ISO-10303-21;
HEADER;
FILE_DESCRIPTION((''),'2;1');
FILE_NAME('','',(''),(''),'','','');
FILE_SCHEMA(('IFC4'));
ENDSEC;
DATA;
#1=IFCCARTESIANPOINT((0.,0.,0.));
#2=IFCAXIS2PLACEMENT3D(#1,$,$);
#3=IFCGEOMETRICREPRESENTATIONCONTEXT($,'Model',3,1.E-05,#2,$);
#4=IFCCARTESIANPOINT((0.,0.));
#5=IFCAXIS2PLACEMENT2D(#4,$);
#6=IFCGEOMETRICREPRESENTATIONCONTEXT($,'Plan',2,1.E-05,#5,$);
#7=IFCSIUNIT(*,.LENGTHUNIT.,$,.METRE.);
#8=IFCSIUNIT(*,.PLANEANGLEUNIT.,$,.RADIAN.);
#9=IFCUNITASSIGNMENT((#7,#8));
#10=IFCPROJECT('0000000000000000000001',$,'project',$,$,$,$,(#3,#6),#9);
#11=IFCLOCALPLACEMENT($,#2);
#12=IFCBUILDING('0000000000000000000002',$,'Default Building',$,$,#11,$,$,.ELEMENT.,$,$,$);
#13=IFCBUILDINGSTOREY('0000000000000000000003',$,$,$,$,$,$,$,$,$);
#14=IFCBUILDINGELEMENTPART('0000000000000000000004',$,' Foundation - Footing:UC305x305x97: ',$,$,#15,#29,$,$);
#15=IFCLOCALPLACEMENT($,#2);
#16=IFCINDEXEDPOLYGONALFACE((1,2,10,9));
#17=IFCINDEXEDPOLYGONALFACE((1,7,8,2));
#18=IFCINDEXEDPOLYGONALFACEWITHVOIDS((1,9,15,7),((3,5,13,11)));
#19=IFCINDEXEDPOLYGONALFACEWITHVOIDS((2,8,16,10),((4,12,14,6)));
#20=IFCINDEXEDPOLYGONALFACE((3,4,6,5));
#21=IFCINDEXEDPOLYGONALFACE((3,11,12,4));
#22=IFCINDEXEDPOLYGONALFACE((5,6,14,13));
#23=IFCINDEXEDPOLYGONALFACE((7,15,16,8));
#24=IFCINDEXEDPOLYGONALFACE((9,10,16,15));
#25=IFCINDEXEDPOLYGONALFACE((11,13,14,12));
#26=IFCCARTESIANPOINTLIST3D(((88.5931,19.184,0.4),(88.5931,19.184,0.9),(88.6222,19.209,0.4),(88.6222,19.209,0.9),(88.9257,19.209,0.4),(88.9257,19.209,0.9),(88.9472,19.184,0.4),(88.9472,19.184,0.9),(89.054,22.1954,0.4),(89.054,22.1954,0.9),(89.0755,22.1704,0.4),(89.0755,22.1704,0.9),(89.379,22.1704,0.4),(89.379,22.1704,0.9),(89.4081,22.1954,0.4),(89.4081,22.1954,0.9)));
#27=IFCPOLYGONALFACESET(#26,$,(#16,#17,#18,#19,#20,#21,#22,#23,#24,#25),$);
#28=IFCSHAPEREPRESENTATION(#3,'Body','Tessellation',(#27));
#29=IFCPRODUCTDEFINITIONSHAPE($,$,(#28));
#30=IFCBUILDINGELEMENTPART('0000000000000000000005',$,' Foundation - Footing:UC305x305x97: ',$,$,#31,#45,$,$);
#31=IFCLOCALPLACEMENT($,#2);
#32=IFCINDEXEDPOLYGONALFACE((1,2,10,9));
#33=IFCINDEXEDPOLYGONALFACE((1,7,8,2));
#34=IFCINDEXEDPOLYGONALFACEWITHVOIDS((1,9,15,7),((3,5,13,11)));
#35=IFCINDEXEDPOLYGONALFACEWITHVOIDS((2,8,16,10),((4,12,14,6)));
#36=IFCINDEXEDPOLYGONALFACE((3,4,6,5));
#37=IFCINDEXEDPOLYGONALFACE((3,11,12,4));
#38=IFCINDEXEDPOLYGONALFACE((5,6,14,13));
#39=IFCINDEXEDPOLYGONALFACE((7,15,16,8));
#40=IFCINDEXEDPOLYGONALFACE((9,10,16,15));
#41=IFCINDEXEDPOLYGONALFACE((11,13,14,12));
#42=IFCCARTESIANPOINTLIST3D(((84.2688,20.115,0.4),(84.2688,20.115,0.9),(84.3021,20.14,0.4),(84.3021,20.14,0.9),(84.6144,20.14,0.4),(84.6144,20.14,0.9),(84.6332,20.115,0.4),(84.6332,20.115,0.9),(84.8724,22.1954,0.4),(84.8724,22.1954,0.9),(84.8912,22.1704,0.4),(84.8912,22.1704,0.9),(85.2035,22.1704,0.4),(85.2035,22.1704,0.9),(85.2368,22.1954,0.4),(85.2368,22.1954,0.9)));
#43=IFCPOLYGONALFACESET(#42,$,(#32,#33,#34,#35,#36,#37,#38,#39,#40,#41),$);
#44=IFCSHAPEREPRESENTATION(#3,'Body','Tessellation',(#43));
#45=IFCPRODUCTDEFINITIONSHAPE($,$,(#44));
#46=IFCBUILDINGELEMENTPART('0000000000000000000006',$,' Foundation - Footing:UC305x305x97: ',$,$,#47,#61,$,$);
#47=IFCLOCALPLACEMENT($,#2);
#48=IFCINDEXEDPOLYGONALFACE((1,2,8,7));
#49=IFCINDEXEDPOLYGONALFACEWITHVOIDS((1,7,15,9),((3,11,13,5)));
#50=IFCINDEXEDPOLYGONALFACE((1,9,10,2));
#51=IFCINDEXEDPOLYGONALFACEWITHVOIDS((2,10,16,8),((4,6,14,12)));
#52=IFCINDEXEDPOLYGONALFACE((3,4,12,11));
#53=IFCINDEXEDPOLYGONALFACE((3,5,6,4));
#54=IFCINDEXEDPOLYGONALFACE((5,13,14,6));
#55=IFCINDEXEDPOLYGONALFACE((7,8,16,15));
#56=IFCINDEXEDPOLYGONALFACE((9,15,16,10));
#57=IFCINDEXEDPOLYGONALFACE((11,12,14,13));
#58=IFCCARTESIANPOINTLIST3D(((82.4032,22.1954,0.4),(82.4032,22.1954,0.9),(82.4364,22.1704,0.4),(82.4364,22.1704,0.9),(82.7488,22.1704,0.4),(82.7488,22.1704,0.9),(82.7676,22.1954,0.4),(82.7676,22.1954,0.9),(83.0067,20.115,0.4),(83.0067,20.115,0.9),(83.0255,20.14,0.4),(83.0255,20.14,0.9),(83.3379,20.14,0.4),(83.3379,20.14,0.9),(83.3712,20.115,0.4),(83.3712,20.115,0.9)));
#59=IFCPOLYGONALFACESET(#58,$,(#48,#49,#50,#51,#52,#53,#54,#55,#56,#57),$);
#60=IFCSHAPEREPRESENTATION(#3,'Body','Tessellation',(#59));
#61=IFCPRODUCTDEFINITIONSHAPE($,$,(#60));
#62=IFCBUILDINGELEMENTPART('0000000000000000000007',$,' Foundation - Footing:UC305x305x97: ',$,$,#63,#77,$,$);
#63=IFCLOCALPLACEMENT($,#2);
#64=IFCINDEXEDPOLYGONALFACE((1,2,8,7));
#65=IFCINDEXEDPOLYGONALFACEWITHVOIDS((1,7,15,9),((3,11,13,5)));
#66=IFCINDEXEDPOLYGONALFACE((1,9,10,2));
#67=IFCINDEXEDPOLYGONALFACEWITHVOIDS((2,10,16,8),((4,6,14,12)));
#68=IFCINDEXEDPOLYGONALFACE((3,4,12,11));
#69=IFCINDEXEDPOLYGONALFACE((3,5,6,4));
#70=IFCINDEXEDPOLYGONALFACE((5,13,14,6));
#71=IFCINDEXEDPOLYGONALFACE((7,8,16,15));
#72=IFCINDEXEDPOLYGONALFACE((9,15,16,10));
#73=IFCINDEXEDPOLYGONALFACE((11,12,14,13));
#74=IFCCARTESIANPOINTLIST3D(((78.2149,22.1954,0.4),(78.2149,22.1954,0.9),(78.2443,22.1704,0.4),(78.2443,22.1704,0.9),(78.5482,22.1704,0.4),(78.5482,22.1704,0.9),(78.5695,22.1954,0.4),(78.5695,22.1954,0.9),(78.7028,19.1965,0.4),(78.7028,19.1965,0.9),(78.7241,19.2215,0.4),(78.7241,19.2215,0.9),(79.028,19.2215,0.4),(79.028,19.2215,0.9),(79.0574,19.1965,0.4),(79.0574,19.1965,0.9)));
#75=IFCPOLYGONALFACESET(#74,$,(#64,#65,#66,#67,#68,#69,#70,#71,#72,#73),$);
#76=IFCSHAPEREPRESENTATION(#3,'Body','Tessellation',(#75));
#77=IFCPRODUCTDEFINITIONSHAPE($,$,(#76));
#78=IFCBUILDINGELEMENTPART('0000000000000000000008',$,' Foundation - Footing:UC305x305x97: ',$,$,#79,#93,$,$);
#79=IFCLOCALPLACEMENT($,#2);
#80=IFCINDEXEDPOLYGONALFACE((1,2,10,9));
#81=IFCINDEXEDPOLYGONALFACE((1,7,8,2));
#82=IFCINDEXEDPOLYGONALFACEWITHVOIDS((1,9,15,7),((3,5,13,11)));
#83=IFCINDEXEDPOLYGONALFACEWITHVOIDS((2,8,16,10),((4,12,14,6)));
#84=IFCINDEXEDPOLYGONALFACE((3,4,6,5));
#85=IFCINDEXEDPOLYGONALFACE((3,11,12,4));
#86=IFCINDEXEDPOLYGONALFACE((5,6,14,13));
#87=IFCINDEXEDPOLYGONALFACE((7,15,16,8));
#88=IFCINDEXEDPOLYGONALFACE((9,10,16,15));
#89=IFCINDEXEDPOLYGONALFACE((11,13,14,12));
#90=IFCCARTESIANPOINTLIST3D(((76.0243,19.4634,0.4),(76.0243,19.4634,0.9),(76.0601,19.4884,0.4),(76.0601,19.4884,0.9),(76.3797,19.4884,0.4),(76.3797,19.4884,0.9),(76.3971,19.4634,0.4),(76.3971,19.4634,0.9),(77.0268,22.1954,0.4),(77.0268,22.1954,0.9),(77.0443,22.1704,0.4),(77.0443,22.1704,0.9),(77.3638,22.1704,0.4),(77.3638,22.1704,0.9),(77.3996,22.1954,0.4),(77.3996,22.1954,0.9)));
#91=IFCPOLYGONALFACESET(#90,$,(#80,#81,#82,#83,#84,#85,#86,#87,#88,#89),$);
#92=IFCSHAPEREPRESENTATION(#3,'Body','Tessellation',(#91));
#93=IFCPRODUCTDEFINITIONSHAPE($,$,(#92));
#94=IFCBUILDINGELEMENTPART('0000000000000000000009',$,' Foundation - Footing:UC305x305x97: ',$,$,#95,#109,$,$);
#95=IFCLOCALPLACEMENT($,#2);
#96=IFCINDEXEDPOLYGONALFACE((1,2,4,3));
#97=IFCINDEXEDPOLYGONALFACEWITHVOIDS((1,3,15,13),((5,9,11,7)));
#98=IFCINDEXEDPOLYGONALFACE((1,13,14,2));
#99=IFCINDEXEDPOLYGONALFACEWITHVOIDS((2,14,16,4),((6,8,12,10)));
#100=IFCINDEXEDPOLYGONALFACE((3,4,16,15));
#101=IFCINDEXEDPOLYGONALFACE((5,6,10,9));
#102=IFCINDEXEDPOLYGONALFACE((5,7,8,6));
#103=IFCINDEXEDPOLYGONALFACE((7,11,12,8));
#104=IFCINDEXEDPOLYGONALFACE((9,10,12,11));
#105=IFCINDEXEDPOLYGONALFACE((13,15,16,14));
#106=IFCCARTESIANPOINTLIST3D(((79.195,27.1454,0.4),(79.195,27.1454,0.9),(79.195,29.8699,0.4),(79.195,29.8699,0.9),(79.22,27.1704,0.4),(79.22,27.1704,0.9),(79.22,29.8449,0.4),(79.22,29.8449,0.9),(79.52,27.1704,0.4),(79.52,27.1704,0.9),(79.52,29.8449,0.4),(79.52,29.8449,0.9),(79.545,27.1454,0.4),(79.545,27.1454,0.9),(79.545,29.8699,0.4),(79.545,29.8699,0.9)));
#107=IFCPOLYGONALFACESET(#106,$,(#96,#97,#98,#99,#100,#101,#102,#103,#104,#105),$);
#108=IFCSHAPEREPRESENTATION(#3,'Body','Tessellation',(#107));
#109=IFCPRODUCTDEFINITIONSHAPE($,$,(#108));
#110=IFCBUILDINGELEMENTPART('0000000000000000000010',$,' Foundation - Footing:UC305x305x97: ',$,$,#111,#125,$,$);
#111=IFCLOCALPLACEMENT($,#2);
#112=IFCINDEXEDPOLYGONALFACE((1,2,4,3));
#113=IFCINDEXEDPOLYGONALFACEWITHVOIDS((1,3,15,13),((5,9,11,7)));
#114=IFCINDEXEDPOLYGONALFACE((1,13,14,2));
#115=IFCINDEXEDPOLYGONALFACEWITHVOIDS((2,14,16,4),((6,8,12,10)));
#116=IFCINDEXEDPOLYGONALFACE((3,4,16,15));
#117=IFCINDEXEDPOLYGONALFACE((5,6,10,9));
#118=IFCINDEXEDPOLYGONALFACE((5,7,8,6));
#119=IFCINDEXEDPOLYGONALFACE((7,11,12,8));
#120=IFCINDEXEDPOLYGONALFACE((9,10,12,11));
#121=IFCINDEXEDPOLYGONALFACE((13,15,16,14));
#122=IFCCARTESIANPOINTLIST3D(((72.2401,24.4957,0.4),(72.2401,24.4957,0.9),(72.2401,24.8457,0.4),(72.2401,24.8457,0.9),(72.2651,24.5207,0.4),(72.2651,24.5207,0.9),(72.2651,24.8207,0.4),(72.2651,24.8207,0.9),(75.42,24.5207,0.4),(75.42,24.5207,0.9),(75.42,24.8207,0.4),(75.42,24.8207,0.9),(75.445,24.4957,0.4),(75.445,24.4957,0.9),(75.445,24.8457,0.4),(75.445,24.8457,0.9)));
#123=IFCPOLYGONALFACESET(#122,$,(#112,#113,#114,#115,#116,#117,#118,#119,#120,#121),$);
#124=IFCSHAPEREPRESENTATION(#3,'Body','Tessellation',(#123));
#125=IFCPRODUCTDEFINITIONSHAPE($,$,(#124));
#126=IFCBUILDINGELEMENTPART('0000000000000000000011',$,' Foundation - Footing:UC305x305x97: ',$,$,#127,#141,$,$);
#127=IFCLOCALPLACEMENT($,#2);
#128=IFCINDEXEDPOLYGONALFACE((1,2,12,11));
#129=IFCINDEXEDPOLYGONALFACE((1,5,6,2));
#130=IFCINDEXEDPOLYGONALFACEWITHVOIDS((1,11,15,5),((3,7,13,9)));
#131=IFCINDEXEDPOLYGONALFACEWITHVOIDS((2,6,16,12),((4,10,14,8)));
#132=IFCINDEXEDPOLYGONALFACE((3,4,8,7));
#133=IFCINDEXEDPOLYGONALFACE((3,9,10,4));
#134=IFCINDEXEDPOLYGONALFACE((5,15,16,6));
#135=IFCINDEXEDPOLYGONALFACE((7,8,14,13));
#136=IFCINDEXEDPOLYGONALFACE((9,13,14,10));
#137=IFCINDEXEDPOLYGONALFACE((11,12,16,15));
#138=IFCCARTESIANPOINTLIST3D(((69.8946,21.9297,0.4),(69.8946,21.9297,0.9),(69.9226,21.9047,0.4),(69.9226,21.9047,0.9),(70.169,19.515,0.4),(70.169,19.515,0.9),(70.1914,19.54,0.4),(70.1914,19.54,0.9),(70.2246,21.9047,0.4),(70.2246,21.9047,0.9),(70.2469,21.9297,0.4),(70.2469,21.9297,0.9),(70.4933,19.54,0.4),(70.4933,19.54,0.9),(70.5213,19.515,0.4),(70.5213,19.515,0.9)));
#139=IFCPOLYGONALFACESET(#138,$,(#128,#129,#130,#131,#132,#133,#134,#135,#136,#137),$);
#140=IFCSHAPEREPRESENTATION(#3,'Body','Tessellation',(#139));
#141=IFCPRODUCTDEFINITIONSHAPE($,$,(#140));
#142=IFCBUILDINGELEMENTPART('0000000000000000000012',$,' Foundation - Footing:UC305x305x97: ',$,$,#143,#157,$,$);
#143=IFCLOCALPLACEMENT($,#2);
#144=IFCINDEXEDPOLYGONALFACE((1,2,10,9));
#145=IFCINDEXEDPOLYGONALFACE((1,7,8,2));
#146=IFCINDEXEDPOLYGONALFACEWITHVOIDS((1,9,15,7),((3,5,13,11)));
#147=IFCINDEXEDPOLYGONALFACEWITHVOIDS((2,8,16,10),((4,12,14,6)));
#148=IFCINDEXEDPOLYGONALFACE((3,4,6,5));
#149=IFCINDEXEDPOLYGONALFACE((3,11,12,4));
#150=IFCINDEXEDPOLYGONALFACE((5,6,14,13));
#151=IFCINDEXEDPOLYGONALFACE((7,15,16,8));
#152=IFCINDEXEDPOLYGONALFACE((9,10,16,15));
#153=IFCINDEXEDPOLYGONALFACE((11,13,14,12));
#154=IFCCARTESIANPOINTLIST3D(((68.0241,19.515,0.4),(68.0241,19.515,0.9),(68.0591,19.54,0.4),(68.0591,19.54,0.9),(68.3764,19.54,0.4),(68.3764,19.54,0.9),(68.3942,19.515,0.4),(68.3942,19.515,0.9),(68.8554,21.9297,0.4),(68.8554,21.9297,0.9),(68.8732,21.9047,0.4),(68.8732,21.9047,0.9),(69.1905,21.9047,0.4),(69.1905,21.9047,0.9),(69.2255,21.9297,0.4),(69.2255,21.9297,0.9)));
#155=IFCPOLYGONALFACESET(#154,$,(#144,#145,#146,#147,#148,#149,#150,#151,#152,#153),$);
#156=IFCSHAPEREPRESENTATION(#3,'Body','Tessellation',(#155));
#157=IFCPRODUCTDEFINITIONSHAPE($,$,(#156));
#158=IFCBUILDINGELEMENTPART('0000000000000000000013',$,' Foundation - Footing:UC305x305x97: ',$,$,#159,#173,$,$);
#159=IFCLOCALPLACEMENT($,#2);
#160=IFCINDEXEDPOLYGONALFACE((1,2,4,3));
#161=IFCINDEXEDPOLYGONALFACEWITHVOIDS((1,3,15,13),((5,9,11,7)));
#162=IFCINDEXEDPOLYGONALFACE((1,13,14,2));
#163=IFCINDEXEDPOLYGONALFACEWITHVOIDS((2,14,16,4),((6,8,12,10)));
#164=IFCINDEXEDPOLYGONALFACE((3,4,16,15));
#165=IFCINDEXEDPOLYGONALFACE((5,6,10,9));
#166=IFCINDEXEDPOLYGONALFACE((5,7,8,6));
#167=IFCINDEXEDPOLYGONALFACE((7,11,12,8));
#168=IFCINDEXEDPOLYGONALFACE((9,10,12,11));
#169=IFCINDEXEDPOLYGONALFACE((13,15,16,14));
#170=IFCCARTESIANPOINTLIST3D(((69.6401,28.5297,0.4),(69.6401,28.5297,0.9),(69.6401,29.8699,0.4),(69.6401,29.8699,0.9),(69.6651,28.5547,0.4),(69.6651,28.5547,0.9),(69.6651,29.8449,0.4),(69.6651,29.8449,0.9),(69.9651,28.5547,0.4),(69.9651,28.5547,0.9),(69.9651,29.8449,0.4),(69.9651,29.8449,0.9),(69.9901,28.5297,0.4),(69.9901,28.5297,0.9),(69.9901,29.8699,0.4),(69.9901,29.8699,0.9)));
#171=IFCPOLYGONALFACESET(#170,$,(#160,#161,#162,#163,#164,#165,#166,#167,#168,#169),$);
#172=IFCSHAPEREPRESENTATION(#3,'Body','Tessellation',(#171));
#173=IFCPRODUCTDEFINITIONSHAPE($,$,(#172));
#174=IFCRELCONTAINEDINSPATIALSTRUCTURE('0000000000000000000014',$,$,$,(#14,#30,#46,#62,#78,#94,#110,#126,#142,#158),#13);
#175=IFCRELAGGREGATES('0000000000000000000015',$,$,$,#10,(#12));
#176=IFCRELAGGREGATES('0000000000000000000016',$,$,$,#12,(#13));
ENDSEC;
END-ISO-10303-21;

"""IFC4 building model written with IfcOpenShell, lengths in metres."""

from ifc_helpers import new_model, si_unit, origin, origin_2d, place, context, project, spatial, polyline, outline, extrude, element, save


model = new_model("IFC4")

# Units and contexts
model_context = context("Model", 3, precision=1e-05, world=origin())
plan_context = context("Plan", 2, precision=1e-05, world=origin_2d())
ifc_project = project(units=[si_unit("LENGTHUNIT", "METRE"), si_unit("PLANEANGLEUNIT", "RADIAN")], contexts=[model_context, plan_context])

# Building, storey
building_placement = place(None, origin())
building = spatial("IfcBuilding", under=ifc_project, at=building_placement, Name="Default Building", CompositionType="ELEMENT")
storey = spatial("IfcBuildingStorey", under=building)

# Building element parts, openings
building_element_part_1 = element("IfcBuildingElementPart", 1, inside=storey, Name=" Foundation - Footing:UC305x305x97: ", context=model_context, shape_type="SweptSolid", body=[
    extrude(outline(polyline([(88.9472, 19.184, 0.4), (88.5931, 19.184, 0.4), (89.054, 22.1954, 0.4), (89.4081, 22.1954, 0.4), (88.9472, 19.184, 0.4)])), None, (0.0, 0.0, 1.0), 0.5),
])
element("IfcOpeningElement", 2, inside=storey, cuts=building_element_part_1, context=model_context, shape_type="SweptSolid", body=[
    extrude(outline(polyline([(88.9257, 19.209, 0.4), (88.6222, 19.209, 0.4), (89.0755, 22.1704, 0.4), (89.379, 22.1704, 0.4), (88.9257, 19.209, 0.4)])), None, (0.0, 0.0, 1.0), 0.5),
])
building_element_part_2 = element("IfcBuildingElementPart", 3, inside=storey, Name=" Foundation - Footing:UC305x305x97: ", context=model_context, shape_type="SweptSolid", body=[
    extrude(outline(polyline([(84.6332, 20.115, 0.4), (84.2688, 20.115, 0.4), (84.8724, 22.1954, 0.4), (85.2368, 22.1954, 0.4), (84.6332, 20.115, 0.4)])), None, (0.0, 0.0, 1.0), 0.5),
])
element("IfcOpeningElement", 4, inside=storey, cuts=building_element_part_2, context=model_context, shape_type="SweptSolid", body=[
    extrude(outline(polyline([(84.6144, 20.14, 0.4), (84.3021, 20.14, 0.4), (84.8912, 22.1704, 0.4), (85.2035, 22.1704, 0.4), (84.6144, 20.14, 0.4)])), None, (0.0, 0.0, 1.0), 0.5),
])
building_element_part_3 = element("IfcBuildingElementPart", 5, inside=storey, Name=" Foundation - Footing:UC305x305x97: ", context=model_context, shape_type="SweptSolid", body=[
    extrude(outline(polyline([(83.3712, 20.115, 0.4), (82.7676, 22.1954, 0.4), (82.4032, 22.1954, 0.4), (83.0067, 20.115, 0.4), (83.3712, 20.115, 0.4)])), None, (0.0, 0.0, 1.0), 0.5),
])
element("IfcOpeningElement", 6, inside=storey, cuts=building_element_part_3, context=model_context, shape_type="SweptSolid", body=[
    extrude(outline(polyline([(83.3379, 20.14, 0.4), (82.7488, 22.1704, 0.4), (82.4364, 22.1704, 0.4), (83.0255, 20.14, 0.4), (83.3379, 20.14, 0.4)])), None, (0.0, 0.0, 1.0), 0.5),
])
building_element_part_4 = element("IfcBuildingElementPart", 7, inside=storey, Name=" Foundation - Footing:UC305x305x97: ", context=model_context, shape_type="SweptSolid", body=[
    extrude(outline(polyline([(79.0574, 19.1965, 0.4), (78.7028, 19.1965, 0.4), (78.2149, 22.1954, 0.4), (78.5695, 22.1954, 0.4), (79.0574, 19.1965, 0.4)])), None, (0.0, 0.0, 1.0), 0.5),
])
element("IfcOpeningElement", 8, inside=storey, cuts=building_element_part_4, context=model_context, shape_type="SweptSolid", body=[
    extrude(outline(polyline([(79.028, 19.2215, 0.4), (78.7241, 19.2215, 0.4), (78.2443, 22.1704, 0.4), (78.5482, 22.1704, 0.4), (79.028, 19.2215, 0.4)])), None, (0.0, 0.0, 1.0), 0.5),
])
building_element_part_5 = element("IfcBuildingElementPart", 9, inside=storey, Name=" Foundation - Footing:UC305x305x97: ", context=model_context, shape_type="SweptSolid", body=[
    extrude(outline(polyline([(76.3971, 19.4634, 0.4), (76.0243, 19.4634, 0.4), (77.0268, 22.1954, 0.4), (77.3996, 22.1954, 0.4), (76.3971, 19.4634, 0.4)])), None, (0.0, 0.0, 1.0), 0.5),
])
element("IfcOpeningElement", 10, inside=storey, cuts=building_element_part_5, context=model_context, shape_type="SweptSolid", body=[
    extrude(outline(polyline([(76.3797, 19.4884, 0.4), (76.0601, 19.4884, 0.4), (77.0443, 22.1704, 0.4), (77.3638, 22.1704, 0.4), (76.3797, 19.4884, 0.4)])), None, (0.0, 0.0, 1.0), 0.5),
])
building_element_part_6 = element("IfcBuildingElementPart", 11, inside=storey, Name=" Foundation - Footing:UC305x305x97: ", context=model_context, shape_type="SweptSolid", body=[
    extrude(outline(polyline([(79.545, 27.1454, 0.4), (79.195, 27.1454, 0.4), (79.195, 29.8699, 0.4), (79.545, 29.8699, 0.4), (79.545, 27.1454, 0.4)])), None, (0.0, 0.0, 1.0), 0.5),
])
element("IfcOpeningElement", 12, inside=storey, cuts=building_element_part_6, context=model_context, shape_type="SweptSolid", body=[
    extrude(outline(polyline([(79.52, 27.1704, 0.4), (79.22, 27.1704, 0.4), (79.22, 29.8449, 0.4), (79.52, 29.8449, 0.4), (79.52, 27.1704, 0.4)])), None, (0.0, 0.0, 1.0), 0.5),
])
building_element_part_7 = element("IfcBuildingElementPart", 13, inside=storey, Name=" Foundation - Footing:UC305x305x97: ", context=model_context, shape_type="SweptSolid", body=[
    extrude(outline(polyline([(75.445, 24.4957, 0.4), (75.445, 24.8457, 0.4), (72.2401, 24.8457, 0.4), (72.2401, 24.4957, 0.4), (75.445, 24.4957, 0.4)])), None, (0.0, 0.0, 1.0), 0.5),
])
element("IfcOpeningElement", 14, inside=storey, cuts=building_element_part_7, context=model_context, shape_type="SweptSolid", body=[
    extrude(outline(polyline([(75.42, 24.5207, 0.4), (75.42, 24.8207, 0.4), (72.2651, 24.8207, 0.4), (72.2651, 24.5207, 0.4), (75.42, 24.5207, 0.4)])), None, (0.0, 0.0, 1.0), 0.5),
])
building_element_part_8 = element("IfcBuildingElementPart", 15, inside=storey, Name=" Foundation - Footing:UC305x305x97: ", context=model_context, shape_type="SweptSolid", body=[
    extrude(outline(polyline([(70.5213, 19.515, 0.4), (70.169, 19.515, 0.4), (69.8946, 21.9297, 0.4), (70.2469, 21.9297, 0.4), (70.5213, 19.515, 0.4)])), None, (0.0, 0.0, 1.0), 0.5),
])
element("IfcOpeningElement", 16, inside=storey, cuts=building_element_part_8, context=model_context, shape_type="SweptSolid", body=[
    extrude(outline(polyline([(70.4933, 19.54, 0.4), (70.1914, 19.54, 0.4), (69.9226, 21.9047, 0.4), (70.2246, 21.9047, 0.4), (70.4933, 19.54, 0.4)])), None, (0.0, 0.0, 1.0), 0.5),
])
building_element_part_9 = element("IfcBuildingElementPart", 17, inside=storey, Name=" Foundation - Footing:UC305x305x97: ", context=model_context, shape_type="SweptSolid", body=[
    extrude(outline(polyline([(68.3942, 19.515, 0.4), (68.0241, 19.515, 0.4), (68.8554, 21.9297, 0.4), (69.2255, 21.9297, 0.4), (68.3942, 19.515, 0.4)])), None, (0.0, 0.0, 1.0), 0.5),
])
element("IfcOpeningElement", 18, inside=storey, cuts=building_element_part_9, context=model_context, shape_type="SweptSolid", body=[
    extrude(outline(polyline([(68.3764, 19.54, 0.4), (68.0591, 19.54, 0.4), (68.8732, 21.9047, 0.4), (69.1905, 21.9047, 0.4), (68.3764, 19.54, 0.4)])), None, (0.0, 0.0, 1.0), 0.5),
])
building_element_part_10 = element("IfcBuildingElementPart", 19, inside=storey, Name=" Foundation - Footing:UC305x305x97: ", context=model_context, shape_type="SweptSolid", body=[
    extrude(outline(polyline([(69.9901, 28.5297, 0.4), (69.6401, 28.5297, 0.4), (69.6401, 29.8699, 0.4), (69.9901, 29.8699, 0.4), (69.9901, 28.5297, 0.4)])), None, (0.0, 0.0, 1.0), 0.5),
])
element("IfcOpeningElement", 20, inside=storey, cuts=building_element_part_10, context=model_context, shape_type="SweptSolid", body=[
    extrude(outline(polyline([(69.9651, 28.5547, 0.4), (69.6651, 28.5547, 0.4), (69.6651, 29.8449, 0.4), (69.9651, 29.8449, 0.4), (69.9651, 28.5547, 0.4)])), None, (0.0, 0.0, 1.0), 0.5),
])

save(model, "model.ifc")
